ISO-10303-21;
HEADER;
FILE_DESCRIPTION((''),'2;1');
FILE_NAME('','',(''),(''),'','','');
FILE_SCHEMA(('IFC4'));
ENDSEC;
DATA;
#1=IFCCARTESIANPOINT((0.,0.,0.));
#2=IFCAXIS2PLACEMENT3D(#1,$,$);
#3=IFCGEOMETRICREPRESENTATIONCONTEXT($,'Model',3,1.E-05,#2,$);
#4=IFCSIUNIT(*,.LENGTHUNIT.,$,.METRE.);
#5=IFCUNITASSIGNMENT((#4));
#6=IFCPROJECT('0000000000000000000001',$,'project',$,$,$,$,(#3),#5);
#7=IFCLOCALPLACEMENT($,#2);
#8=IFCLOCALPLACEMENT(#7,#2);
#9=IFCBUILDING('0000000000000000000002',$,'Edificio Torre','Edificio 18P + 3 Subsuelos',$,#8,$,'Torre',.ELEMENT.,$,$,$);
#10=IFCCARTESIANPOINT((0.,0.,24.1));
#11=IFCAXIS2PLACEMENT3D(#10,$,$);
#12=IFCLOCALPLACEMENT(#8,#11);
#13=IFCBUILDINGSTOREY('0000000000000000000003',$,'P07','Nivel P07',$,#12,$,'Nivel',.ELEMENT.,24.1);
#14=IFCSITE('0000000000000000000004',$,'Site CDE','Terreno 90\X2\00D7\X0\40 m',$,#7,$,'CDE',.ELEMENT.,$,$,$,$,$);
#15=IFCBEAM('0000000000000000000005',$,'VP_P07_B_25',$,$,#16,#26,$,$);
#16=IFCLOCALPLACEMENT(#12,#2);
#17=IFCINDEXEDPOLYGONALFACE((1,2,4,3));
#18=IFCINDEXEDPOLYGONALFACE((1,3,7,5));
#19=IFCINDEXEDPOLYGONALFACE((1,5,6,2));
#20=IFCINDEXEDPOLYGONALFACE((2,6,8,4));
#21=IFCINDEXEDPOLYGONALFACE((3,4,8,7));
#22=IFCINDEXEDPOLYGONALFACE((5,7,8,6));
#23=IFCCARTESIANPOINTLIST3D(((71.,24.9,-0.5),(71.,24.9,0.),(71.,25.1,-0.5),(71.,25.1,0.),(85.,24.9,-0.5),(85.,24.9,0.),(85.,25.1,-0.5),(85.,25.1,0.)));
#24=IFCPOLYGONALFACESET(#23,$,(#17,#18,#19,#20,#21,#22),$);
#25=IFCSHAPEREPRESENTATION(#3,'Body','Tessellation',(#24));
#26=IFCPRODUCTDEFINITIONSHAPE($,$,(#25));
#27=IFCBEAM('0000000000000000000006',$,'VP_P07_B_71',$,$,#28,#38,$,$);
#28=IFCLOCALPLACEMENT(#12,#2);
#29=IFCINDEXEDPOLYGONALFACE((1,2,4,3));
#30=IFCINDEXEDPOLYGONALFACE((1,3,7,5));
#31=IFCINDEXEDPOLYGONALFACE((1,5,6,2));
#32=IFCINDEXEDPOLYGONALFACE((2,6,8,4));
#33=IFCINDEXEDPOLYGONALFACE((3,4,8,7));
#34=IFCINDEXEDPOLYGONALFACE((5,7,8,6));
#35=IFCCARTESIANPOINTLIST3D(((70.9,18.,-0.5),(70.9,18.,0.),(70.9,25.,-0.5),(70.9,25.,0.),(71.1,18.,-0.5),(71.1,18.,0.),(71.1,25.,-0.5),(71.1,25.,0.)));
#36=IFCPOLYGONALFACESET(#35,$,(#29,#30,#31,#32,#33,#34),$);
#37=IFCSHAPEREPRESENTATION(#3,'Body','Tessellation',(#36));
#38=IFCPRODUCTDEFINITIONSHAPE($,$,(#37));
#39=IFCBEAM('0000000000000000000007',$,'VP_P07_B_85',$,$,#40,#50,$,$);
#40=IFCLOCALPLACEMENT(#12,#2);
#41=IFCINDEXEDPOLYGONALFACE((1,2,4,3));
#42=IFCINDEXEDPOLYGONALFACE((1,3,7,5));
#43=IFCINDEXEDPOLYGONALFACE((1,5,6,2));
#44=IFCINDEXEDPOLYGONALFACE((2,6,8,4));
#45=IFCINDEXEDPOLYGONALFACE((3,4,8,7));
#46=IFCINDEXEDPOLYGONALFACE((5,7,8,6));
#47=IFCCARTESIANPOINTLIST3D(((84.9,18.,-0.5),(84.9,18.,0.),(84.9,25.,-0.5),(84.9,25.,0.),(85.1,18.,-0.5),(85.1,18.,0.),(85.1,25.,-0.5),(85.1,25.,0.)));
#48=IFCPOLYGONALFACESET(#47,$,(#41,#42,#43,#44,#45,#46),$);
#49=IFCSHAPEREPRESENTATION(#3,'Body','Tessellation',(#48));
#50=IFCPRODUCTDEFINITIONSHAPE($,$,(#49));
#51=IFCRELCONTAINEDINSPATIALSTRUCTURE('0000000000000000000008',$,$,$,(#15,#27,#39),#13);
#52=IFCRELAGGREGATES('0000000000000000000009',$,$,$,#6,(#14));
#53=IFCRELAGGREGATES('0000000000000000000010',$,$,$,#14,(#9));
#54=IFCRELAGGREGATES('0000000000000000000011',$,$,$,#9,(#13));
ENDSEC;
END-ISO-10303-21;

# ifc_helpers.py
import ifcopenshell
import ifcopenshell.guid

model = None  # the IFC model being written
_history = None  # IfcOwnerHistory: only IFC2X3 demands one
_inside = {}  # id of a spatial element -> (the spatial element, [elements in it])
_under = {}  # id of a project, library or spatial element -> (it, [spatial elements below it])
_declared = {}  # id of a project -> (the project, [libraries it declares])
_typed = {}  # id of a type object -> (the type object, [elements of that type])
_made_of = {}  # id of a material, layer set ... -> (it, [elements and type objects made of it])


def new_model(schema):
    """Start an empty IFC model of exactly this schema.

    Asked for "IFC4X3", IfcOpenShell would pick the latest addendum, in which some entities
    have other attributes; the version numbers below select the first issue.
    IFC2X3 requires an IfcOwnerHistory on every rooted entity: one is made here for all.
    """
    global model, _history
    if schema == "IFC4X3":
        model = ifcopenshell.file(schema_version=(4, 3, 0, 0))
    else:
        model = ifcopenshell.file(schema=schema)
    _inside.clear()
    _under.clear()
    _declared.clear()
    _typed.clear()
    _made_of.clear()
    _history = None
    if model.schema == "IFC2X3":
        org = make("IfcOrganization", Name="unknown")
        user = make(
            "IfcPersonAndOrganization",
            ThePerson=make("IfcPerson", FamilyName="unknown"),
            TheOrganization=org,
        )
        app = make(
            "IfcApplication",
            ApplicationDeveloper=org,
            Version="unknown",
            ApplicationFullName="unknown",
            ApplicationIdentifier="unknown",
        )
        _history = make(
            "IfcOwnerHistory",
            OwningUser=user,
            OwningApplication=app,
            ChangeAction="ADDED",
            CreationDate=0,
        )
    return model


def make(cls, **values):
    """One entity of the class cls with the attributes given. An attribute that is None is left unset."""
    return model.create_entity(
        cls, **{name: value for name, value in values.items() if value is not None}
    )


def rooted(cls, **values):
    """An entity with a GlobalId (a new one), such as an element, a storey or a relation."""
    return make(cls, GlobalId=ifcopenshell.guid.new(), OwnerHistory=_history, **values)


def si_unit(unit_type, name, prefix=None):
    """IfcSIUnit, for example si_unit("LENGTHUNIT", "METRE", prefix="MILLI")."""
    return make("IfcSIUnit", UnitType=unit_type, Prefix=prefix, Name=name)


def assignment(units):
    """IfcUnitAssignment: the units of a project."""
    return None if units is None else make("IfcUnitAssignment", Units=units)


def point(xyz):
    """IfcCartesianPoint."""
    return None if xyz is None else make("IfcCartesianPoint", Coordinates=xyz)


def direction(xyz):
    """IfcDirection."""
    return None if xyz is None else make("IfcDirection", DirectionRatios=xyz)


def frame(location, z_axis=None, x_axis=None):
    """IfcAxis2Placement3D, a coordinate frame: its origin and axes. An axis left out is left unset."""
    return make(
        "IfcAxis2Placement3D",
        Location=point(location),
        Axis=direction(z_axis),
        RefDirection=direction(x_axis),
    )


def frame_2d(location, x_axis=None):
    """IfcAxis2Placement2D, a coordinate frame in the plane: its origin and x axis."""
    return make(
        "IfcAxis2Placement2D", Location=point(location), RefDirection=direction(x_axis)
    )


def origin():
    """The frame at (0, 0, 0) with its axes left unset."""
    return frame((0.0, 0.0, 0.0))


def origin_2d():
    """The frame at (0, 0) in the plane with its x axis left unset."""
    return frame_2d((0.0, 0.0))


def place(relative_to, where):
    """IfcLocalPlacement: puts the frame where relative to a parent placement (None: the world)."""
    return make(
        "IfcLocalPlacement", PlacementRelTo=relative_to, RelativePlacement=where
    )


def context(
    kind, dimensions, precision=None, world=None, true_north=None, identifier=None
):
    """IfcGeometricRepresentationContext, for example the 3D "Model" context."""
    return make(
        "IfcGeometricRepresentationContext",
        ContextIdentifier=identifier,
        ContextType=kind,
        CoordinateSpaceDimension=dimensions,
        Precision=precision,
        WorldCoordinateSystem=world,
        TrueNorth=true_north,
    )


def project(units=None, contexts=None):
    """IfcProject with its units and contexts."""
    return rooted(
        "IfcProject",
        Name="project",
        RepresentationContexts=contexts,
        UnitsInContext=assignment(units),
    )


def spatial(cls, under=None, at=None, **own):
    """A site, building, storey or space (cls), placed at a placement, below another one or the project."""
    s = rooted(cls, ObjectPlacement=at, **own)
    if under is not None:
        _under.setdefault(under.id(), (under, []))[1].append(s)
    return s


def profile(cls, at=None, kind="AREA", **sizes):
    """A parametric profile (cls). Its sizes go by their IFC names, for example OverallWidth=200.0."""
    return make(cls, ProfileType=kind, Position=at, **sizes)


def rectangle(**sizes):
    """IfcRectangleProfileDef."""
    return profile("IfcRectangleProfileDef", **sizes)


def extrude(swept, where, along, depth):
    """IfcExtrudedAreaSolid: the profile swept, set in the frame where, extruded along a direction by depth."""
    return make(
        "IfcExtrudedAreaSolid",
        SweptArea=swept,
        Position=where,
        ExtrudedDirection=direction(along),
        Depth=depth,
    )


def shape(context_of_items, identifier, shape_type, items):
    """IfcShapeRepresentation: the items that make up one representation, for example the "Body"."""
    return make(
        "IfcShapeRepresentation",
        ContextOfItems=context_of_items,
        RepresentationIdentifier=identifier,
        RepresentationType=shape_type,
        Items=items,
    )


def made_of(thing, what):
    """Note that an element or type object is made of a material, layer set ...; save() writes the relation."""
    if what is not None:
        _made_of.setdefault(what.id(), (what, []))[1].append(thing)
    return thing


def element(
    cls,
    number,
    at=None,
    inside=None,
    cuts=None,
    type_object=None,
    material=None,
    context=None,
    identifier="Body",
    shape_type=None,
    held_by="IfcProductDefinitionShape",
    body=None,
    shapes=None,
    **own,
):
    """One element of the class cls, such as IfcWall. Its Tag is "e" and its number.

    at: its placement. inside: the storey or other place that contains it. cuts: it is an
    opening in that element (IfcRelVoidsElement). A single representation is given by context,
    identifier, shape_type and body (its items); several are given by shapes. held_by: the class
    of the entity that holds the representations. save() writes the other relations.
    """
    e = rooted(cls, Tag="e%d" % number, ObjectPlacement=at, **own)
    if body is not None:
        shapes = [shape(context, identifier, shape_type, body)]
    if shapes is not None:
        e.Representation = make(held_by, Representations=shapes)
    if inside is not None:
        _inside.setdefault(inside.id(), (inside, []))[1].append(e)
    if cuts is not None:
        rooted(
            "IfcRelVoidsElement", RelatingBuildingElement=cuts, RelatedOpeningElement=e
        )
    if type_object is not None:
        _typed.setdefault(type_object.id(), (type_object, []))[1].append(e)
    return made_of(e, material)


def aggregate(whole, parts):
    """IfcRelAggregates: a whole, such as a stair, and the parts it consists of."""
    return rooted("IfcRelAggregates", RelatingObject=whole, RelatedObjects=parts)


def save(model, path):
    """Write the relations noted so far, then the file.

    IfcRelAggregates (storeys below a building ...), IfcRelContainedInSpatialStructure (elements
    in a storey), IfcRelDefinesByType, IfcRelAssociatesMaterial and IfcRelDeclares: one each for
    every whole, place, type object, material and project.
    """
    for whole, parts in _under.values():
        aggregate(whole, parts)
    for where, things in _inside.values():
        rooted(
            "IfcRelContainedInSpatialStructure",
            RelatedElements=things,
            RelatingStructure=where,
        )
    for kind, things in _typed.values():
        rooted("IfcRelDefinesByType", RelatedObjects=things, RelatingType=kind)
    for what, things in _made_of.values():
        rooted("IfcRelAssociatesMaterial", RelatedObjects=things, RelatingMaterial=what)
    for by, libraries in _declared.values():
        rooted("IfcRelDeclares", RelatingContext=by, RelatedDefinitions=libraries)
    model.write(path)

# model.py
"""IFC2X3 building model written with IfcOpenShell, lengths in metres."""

from ifc_helpers import new_model, si_unit, frame, origin, origin_2d, place, context, project, spatial, rectangle, extrude, element, save


model = new_model("IFC2X3")

# Units and contexts
model_context = context("Model", 3, precision=1e-05, world=origin())
ifc_project = project(units=[si_unit("LENGTHUNIT", "METRE")], contexts=[model_context])

# Site, building, storey
site_placement = place(None, origin())
site = spatial("IfcSite", under=ifc_project, at=site_placement, Name="Site CDE", Description="Terreno 90×40 m", LongName="CDE", CompositionType="ELEMENT")
building_placement = place(site_placement, origin())
building = spatial("IfcBuilding", under=site, at=building_placement, Name="Edificio Torre", Description="Edificio 18P + 3 Subsuelos", LongName="Torre", CompositionType="ELEMENT")
storey_placement = place(building_placement, frame((0.0, 0.0, 24.1)))
storey = spatial("IfcBuildingStorey", under=building, at=storey_placement, Name="P07", Description="Nivel P07", LongName="Nivel", CompositionType="ELEMENT", Elevation=24.1)

# Beams
for number, where, name in (
    (1, (78.0, 25.0, -0.5), "VP_P07_B_25"),
):
    element("IfcBeam", number, at=place(storey_placement, frame(where)), inside=storey, Name=name, context=model_context, shape_type="SweptSolid", body=[
        extrude(rectangle(XDim=14.0, YDim=0.2, at=origin_2d()), origin(), (0.0, 0.0, 1.0), 0.5),
    ])
for number, where, name in (
    (2, (71.0, 21.5, -0.5), "VP_P07_B_71"),
    (3, (85.0, 21.5, -0.5), "VP_P07_B_85"),
):
    element("IfcBeam", number, at=place(storey_placement, frame(where)), inside=storey, Name=name, context=model_context, shape_type="SweptSolid", body=[
        extrude(rectangle(XDim=0.2, YDim=7.0, at=origin_2d()), origin(), (0.0, 0.0, 1.0), 0.5),
    ])

save(model, "model.ifc")
